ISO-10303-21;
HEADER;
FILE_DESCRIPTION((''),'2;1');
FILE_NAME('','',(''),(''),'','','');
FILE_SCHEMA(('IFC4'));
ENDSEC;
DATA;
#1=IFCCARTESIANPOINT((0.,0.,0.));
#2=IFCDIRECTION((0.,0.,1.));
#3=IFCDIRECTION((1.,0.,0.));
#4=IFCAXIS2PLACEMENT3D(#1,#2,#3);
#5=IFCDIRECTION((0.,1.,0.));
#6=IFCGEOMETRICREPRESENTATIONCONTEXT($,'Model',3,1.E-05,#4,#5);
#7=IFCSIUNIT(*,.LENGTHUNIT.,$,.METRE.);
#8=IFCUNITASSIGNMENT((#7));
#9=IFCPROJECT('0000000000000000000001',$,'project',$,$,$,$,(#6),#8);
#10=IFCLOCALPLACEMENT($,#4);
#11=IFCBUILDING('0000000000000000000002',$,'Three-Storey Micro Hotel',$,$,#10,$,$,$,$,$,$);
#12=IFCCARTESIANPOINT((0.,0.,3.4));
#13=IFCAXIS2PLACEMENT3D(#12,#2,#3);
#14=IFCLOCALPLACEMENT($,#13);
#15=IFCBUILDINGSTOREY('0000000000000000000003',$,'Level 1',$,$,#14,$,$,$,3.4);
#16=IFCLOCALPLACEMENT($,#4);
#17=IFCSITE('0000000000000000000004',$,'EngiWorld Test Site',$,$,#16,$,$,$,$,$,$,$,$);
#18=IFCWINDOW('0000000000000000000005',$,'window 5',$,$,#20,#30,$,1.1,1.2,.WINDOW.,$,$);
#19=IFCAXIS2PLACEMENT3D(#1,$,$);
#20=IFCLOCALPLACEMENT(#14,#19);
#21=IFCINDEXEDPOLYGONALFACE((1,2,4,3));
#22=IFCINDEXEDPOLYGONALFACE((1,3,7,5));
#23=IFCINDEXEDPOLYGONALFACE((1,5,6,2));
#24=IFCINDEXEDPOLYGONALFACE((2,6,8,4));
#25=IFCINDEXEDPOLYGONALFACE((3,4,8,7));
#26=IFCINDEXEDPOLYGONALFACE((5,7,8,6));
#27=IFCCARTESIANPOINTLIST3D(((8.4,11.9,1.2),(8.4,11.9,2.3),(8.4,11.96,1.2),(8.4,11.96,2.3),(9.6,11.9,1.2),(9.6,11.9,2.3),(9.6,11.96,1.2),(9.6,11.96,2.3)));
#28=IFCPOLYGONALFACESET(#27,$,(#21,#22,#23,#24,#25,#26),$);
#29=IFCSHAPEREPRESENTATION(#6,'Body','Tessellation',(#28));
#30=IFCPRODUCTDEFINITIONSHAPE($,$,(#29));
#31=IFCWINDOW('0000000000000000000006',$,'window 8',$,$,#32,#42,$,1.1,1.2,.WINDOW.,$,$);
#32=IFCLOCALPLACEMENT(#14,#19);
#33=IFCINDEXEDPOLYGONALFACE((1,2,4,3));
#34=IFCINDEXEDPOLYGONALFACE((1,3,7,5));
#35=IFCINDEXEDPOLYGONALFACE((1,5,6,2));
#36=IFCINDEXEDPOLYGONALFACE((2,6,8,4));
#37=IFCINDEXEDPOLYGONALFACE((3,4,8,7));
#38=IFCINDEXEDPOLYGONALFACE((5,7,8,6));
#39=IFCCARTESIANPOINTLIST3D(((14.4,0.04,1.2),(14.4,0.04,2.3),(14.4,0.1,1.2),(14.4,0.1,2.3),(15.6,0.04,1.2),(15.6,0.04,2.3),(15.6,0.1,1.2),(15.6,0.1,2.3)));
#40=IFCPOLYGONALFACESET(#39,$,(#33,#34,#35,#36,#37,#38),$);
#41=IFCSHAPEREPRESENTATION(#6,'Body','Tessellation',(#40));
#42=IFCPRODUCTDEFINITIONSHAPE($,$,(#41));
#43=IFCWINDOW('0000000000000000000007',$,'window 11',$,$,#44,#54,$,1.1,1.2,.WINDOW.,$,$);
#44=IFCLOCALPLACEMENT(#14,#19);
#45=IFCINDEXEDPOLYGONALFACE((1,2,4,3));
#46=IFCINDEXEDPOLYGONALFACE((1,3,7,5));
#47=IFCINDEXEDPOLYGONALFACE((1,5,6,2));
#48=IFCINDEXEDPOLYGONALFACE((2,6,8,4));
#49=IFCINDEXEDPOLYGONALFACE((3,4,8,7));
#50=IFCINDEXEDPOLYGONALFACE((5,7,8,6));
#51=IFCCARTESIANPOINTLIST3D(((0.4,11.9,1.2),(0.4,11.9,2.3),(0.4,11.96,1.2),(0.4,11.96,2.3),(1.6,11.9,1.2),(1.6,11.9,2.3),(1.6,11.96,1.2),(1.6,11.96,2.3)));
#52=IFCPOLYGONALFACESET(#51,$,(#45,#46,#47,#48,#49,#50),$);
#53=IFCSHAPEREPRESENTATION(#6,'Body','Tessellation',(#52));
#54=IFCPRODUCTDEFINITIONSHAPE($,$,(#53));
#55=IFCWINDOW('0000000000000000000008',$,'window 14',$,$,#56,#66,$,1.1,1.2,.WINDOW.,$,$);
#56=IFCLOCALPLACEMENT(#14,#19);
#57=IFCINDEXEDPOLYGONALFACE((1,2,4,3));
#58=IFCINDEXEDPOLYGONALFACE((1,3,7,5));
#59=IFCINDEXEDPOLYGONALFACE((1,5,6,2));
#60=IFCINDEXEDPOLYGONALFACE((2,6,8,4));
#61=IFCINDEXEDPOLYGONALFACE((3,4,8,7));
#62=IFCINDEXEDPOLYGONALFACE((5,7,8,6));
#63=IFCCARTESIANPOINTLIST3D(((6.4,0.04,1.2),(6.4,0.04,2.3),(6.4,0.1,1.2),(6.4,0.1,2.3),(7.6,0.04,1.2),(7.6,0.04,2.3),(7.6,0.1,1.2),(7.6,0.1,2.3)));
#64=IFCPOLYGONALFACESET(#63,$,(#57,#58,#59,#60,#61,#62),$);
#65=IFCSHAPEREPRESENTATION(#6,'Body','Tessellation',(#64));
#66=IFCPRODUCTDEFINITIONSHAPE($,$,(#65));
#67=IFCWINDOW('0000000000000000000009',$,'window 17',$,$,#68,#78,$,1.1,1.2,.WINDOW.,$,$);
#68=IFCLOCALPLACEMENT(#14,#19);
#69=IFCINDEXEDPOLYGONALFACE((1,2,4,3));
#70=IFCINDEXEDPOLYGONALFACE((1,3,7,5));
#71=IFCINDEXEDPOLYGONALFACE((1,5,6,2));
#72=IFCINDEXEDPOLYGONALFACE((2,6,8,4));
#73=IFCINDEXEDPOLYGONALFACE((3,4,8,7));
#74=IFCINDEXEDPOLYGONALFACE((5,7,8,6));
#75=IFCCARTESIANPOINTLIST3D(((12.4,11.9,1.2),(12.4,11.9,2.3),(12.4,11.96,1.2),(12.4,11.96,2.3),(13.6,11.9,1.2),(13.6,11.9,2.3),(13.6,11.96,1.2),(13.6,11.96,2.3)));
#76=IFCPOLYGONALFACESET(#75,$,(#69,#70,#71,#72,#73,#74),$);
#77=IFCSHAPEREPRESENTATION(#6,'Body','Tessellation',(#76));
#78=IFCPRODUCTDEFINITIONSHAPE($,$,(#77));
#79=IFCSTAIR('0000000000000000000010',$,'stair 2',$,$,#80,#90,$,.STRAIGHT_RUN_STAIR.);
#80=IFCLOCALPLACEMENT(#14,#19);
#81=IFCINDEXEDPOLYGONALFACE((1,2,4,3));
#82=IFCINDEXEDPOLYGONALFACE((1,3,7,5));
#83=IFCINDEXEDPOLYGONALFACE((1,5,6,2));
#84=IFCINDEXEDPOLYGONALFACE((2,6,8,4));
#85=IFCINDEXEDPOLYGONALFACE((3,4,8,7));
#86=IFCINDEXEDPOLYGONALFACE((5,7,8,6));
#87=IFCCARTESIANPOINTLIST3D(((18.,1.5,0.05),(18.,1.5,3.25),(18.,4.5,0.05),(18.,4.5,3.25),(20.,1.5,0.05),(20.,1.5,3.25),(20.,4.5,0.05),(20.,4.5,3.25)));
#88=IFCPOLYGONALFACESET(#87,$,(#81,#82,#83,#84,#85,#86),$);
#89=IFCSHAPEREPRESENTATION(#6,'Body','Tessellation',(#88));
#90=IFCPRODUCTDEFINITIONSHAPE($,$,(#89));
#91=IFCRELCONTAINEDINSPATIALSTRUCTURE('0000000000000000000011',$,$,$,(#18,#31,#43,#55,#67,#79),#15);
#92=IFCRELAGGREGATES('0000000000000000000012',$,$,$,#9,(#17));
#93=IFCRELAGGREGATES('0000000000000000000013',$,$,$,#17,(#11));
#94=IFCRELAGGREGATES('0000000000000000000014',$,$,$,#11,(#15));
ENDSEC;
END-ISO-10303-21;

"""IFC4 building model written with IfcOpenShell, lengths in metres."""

from ifc_helpers import new_model, si_unit, direction, frame, origin_with_axes, origin_2d_with_axis, place, context, project, spatial, rectangle, extrude, element, save


model = new_model("IFC4")

# Units and contexts
model_context = context("Model", 3, precision=1e-05, world=origin_with_axes(), true_north=direction((0.0, 1.0, 0.0)))
ifc_project = project(units=[si_unit("LENGTHUNIT", "METRE")], contexts=[model_context])

# Site, building, storey
site_placement = place(None, origin_with_axes())
site = spatial("IfcSite", under=ifc_project, at=site_placement, Name="EngiWorld Test Site")
building_placement = place(None, origin_with_axes())
building = spatial("IfcBuilding", under=site, at=building_placement, Name="Three-Storey Micro Hotel")
storey_placement = place(None, frame((0.0, 0.0, 3.4), z_axis=(0.0, 0.0, 1.0), x_axis=(1.0, 0.0, 0.0)))
storey = spatial("IfcBuildingStorey", under=building, at=storey_placement, Name="Level 1", Elevation=3.4)

# Windows
for number, where, z_axis, x_axis, name in (
    (1, (9.0, 11.93, 4.6), (0.0, 0.0, 1.0), (1.0, 0.0, 0.0), "window 5"),
    (2, (15.0, 0.07, 4.6), (0.0, 0.0, 1.0), (1.0, 0.0, 0.0), "window 8"),
    (3, (1.0, 11.93, 4.6), (0.0, 0.0, 1.0), (1.0, 0.0, 0.0), "window 11"),
    (4, (7.0, 0.07, 4.6), (0.0, 0.0, 1.0), (1.0, 0.0, 0.0), "window 14"),
    (5, (13.0, 11.93, 4.6), (0.0, 0.0, 1.0), (1.0, 0.0, 0.0), "window 17"),
):
    element("IfcWindow", number, at=place(None, frame(where, z_axis=z_axis, x_axis=x_axis)), inside=storey, Name=name, OverallHeight=1.1, OverallWidth=1.2, PredefinedType="WINDOW", context=model_context, shape_type="SweptSolid", body=[
        extrude(rectangle(XDim=1.2, YDim=0.06, at=origin_2d_with_axis()), origin_with_axes(), (0.0, 0.0, 1.0), 1.1),
    ])

# Stair
stair_placement = place(None, frame((19.0, 3.0, 3.45), z_axis=(0.0, 0.0, 1.0), x_axis=(1.0, 0.0, 0.0)))
element("IfcStair", 6, at=stair_placement, inside=storey, Name="stair 2", PredefinedType="STRAIGHT_RUN_STAIR", context=model_context, shape_type="SweptSolid", body=[
    extrude(rectangle(XDim=2.0, YDim=3.0, at=origin_2d_with_axis()), origin_with_axes(), (0.0, 0.0, 1.0), 3.2),
])

save(model, "model.ifc")
